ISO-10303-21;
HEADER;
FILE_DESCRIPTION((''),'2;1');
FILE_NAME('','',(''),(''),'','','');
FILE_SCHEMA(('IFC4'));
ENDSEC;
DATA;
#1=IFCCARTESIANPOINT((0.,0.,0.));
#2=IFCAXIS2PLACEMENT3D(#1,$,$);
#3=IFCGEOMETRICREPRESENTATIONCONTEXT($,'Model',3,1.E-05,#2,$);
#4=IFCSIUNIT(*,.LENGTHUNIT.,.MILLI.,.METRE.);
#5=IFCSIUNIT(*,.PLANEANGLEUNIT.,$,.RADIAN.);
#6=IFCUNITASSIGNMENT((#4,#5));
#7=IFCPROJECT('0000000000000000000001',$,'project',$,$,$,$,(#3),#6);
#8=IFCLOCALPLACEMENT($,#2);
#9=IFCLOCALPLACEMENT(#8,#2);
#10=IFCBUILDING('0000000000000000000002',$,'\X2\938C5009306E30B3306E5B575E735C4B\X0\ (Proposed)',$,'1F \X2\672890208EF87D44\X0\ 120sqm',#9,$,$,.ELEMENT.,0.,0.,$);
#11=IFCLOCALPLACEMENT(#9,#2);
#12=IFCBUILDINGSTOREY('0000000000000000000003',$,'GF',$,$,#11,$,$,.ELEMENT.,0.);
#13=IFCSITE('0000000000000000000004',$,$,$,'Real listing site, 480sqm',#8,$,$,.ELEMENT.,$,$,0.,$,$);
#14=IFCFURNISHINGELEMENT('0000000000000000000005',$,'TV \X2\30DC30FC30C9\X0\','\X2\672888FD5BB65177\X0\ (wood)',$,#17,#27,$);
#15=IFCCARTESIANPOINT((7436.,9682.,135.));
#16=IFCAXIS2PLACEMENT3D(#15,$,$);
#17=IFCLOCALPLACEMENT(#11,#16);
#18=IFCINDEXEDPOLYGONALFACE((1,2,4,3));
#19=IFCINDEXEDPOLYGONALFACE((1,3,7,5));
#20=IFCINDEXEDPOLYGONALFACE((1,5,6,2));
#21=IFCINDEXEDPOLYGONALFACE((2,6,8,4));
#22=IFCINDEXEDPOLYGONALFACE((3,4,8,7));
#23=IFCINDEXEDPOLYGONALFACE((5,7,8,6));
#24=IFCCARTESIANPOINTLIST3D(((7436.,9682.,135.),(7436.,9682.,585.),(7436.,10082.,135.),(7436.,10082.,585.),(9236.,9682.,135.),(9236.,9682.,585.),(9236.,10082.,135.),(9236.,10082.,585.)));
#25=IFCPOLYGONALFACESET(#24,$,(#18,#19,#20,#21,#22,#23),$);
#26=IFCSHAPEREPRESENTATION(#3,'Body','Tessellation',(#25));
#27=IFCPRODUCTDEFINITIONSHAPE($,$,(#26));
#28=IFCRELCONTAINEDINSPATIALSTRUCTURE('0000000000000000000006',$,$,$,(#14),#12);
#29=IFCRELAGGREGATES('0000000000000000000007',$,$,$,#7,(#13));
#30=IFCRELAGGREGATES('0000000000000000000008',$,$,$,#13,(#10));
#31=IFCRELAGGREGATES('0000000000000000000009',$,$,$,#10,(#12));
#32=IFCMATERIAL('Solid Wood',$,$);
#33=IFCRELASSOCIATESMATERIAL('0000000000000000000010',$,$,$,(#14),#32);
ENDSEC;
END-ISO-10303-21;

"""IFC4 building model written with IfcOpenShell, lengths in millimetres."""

from ifc_helpers import new_model, si_unit, frame, frame_2d, origin, place, context, project, spatial, rectangle, extrude, material, element, save


model = new_model("IFC4")

# Units and contexts
model_context = context("Model", 3, precision=1e-05, world=origin())
ifc_project = project(units=[si_unit("LENGTHUNIT", "METRE", prefix="MILLI"), si_unit("PLANEANGLEUNIT", "RADIAN")], contexts=[model_context])

# Site, building, storey
site_placement = place(None, origin())
site = spatial("IfcSite", under=ifc_project, at=site_placement, ObjectType="Real listing site, 480sqm", CompositionType="ELEMENT", RefElevation=0.0)
building_placement = place(site_placement, origin())
building = spatial("IfcBuilding", under=site, at=building_placement, Name="鎌倉のコの字平屋 (Proposed)", ObjectType="1F 木造軸組 120sqm", CompositionType="ELEMENT", ElevationOfRefHeight=0.0, ElevationOfTerrain=0.0)
storey_placement = place(building_placement, origin())
storey = spatial("IfcBuildingStorey", under=building, at=storey_placement, Name="GF", CompositionType="ELEMENT", Elevation=0.0)

# Shared definitions
ifc_material_1 = material(Name="Solid Wood")

# Furnishing element
furnishing_1_placement = place(storey_placement, frame((7436.0, 9682.0, 135.0)))
element("IfcFurnishingElement", 1, at=furnishing_1_placement, inside=storey, material=ifc_material_1, Name="TV ボード", Description="木製家具 (wood)", context=model_context, shape_type="SweptSolid", body=[
    extrude(rectangle(XDim=1800.0, YDim=400.0, at=frame_2d((900.0, 200.0))), frame((7436.0, 9682.0, 135.0)), (0.0, 0.0, 1.0), 450.0),
])

save(model, "model.ifc")
